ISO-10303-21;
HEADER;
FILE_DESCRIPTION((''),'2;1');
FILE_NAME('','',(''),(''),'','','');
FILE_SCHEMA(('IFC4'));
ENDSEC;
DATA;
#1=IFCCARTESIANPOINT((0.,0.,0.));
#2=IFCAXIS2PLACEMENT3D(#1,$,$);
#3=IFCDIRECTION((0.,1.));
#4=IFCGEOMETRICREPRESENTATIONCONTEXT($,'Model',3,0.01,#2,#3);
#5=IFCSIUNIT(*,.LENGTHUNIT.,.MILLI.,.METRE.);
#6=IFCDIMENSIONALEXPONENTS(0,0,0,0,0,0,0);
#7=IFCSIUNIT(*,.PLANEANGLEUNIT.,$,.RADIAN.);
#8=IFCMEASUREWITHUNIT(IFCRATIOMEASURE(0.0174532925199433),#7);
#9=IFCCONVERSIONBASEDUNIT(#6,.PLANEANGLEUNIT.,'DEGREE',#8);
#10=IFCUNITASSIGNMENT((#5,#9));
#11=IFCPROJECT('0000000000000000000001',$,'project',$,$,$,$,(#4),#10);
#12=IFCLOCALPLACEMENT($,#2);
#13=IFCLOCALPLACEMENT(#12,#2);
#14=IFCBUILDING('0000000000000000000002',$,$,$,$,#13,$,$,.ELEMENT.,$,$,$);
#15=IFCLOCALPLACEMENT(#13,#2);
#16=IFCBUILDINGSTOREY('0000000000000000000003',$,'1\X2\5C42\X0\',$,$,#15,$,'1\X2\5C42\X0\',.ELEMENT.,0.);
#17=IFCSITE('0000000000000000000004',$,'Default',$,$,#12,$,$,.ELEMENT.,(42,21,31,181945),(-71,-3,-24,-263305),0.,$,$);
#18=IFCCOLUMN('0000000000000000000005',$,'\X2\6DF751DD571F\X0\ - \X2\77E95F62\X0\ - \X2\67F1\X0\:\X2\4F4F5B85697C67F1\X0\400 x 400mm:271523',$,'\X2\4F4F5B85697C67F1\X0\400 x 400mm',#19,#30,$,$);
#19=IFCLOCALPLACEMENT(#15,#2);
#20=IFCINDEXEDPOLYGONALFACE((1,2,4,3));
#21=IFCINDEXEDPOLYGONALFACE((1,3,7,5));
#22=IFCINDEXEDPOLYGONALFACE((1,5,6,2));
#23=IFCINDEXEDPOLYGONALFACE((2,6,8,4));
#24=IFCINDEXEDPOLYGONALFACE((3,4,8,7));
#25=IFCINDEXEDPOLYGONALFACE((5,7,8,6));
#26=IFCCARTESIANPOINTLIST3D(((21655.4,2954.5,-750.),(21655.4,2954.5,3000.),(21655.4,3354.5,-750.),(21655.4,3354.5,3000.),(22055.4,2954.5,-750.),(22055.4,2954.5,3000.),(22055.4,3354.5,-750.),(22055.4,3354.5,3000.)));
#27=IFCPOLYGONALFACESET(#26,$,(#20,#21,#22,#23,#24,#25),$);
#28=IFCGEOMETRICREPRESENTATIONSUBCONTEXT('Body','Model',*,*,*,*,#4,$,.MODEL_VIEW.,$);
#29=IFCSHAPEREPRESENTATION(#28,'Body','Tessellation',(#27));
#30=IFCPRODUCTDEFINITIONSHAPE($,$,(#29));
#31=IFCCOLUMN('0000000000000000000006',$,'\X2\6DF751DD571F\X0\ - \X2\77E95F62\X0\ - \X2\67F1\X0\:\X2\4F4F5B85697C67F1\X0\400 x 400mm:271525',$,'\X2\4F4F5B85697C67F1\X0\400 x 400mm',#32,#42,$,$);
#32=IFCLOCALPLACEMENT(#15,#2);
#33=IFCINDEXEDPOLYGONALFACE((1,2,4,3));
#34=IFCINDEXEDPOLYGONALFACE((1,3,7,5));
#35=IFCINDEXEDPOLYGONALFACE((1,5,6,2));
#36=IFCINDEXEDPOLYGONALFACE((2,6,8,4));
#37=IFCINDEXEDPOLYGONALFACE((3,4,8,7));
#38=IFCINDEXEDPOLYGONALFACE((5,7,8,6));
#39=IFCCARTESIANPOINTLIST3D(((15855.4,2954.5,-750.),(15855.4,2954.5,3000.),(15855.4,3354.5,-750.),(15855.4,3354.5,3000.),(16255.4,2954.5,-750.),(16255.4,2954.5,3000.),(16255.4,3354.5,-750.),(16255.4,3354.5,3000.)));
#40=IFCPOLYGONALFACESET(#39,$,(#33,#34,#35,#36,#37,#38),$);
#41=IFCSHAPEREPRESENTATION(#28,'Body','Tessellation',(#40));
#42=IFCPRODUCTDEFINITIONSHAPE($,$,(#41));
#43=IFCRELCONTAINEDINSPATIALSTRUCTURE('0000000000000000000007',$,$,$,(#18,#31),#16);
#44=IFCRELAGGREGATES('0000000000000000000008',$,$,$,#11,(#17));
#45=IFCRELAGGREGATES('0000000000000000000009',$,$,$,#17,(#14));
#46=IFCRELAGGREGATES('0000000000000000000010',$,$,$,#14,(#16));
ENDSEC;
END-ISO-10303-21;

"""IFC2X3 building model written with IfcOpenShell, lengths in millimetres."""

from ifc_helpers import new_model, entity, si_unit, converted_unit, direction, frame, frame_2d, origin, origin_2d_with_axis, place, context, subcontext, project, spatial, rectangle, extrude, source, transform, mapped, element, save


model = new_model("IFC2X3")

# Units and contexts
model_context = context("Model", 3, precision=0.01, world=origin(), true_north=direction((0.0, 1.0)))
body_context = subcontext(model_context, "Body", "Model", "MODEL_VIEW")
ifc_project = project(units=[si_unit("LENGTHUNIT", "METRE", prefix="MILLI"), converted_unit("PLANEANGLEUNIT", "DEGREE", entity("IfcRatioMeasure", 0.0174532925199433), si_unit("PLANEANGLEUNIT", "RADIAN"), dimensions=[0, 0, 0, 0, 0, 0, 0])], contexts=[model_context])

# Site, building, storey
site_placement = place(None, origin())
site = spatial("IfcSite", under=ifc_project, at=site_placement, Name="Default", CompositionType="ELEMENT", RefLatitude=(42, 21, 31, 181945), RefLongitude=(-71, -3, -24, -263305), RefElevation=0.0)
building_placement = place(site_placement, origin())
building = spatial("IfcBuilding", under=site, at=building_placement, CompositionType="ELEMENT")
storey_placement = place(building_placement, origin())
storey = spatial("IfcBuildingStorey", under=building, at=storey_placement, Name="1层", LongName="1层", CompositionType="ELEMENT", Elevation=0.0)

# Columns
shared_shape_1 = source(origin(), body_context, "Body", "SweptSolid", [
    extrude(rectangle(XDim=400.0, YDim=400.0, at=frame_2d((0.0, 0.0), x_axis=(1.0, 0.0))), frame((21855.4, 3154.5, -750.0), z_axis=(0.0, 0.0, 1.0), x_axis=(0.0, -1.0, 0.0)), (0.0, 0.0, 1.0), 3750.0),
])
column_1_placement = place(storey_placement, origin())
element("IfcColumn", 1, at=column_1_placement, inside=storey, Name="混凝土 - 矩形 - 柱:住宅楼柱400 x 400mm:271523", ObjectType="住宅楼柱400 x 400mm", context=body_context, shape_type="MappedRepresentation", body=[
    mapped(shared_shape_1, transform((0.0, 0.0, 0.0), scale=1.0)),
])
shared_shape_2 = source(origin(), body_context, "Body", "SweptSolid", [
    extrude(rectangle(XDim=400.0, YDim=400.0, at=origin_2d_with_axis()), frame((16055.4, 3154.5, -750.0), z_axis=(0.0, 0.0, 1.0), x_axis=(0.0, -1.0, 0.0)), (0.0, 0.0, 1.0), 3750.0),
])
column_2_placement = place(storey_placement, origin())
element("IfcColumn", 2, at=column_2_placement, inside=storey, Name="混凝土 - 矩形 - 柱:住宅楼柱400 x 400mm:271525", ObjectType="住宅楼柱400 x 400mm", context=body_context, shape_type="MappedRepresentation", body=[
    mapped(shared_shape_2, transform((0.0, 0.0, 0.0), scale=1.0)),
])

save(model, "model.ifc")
